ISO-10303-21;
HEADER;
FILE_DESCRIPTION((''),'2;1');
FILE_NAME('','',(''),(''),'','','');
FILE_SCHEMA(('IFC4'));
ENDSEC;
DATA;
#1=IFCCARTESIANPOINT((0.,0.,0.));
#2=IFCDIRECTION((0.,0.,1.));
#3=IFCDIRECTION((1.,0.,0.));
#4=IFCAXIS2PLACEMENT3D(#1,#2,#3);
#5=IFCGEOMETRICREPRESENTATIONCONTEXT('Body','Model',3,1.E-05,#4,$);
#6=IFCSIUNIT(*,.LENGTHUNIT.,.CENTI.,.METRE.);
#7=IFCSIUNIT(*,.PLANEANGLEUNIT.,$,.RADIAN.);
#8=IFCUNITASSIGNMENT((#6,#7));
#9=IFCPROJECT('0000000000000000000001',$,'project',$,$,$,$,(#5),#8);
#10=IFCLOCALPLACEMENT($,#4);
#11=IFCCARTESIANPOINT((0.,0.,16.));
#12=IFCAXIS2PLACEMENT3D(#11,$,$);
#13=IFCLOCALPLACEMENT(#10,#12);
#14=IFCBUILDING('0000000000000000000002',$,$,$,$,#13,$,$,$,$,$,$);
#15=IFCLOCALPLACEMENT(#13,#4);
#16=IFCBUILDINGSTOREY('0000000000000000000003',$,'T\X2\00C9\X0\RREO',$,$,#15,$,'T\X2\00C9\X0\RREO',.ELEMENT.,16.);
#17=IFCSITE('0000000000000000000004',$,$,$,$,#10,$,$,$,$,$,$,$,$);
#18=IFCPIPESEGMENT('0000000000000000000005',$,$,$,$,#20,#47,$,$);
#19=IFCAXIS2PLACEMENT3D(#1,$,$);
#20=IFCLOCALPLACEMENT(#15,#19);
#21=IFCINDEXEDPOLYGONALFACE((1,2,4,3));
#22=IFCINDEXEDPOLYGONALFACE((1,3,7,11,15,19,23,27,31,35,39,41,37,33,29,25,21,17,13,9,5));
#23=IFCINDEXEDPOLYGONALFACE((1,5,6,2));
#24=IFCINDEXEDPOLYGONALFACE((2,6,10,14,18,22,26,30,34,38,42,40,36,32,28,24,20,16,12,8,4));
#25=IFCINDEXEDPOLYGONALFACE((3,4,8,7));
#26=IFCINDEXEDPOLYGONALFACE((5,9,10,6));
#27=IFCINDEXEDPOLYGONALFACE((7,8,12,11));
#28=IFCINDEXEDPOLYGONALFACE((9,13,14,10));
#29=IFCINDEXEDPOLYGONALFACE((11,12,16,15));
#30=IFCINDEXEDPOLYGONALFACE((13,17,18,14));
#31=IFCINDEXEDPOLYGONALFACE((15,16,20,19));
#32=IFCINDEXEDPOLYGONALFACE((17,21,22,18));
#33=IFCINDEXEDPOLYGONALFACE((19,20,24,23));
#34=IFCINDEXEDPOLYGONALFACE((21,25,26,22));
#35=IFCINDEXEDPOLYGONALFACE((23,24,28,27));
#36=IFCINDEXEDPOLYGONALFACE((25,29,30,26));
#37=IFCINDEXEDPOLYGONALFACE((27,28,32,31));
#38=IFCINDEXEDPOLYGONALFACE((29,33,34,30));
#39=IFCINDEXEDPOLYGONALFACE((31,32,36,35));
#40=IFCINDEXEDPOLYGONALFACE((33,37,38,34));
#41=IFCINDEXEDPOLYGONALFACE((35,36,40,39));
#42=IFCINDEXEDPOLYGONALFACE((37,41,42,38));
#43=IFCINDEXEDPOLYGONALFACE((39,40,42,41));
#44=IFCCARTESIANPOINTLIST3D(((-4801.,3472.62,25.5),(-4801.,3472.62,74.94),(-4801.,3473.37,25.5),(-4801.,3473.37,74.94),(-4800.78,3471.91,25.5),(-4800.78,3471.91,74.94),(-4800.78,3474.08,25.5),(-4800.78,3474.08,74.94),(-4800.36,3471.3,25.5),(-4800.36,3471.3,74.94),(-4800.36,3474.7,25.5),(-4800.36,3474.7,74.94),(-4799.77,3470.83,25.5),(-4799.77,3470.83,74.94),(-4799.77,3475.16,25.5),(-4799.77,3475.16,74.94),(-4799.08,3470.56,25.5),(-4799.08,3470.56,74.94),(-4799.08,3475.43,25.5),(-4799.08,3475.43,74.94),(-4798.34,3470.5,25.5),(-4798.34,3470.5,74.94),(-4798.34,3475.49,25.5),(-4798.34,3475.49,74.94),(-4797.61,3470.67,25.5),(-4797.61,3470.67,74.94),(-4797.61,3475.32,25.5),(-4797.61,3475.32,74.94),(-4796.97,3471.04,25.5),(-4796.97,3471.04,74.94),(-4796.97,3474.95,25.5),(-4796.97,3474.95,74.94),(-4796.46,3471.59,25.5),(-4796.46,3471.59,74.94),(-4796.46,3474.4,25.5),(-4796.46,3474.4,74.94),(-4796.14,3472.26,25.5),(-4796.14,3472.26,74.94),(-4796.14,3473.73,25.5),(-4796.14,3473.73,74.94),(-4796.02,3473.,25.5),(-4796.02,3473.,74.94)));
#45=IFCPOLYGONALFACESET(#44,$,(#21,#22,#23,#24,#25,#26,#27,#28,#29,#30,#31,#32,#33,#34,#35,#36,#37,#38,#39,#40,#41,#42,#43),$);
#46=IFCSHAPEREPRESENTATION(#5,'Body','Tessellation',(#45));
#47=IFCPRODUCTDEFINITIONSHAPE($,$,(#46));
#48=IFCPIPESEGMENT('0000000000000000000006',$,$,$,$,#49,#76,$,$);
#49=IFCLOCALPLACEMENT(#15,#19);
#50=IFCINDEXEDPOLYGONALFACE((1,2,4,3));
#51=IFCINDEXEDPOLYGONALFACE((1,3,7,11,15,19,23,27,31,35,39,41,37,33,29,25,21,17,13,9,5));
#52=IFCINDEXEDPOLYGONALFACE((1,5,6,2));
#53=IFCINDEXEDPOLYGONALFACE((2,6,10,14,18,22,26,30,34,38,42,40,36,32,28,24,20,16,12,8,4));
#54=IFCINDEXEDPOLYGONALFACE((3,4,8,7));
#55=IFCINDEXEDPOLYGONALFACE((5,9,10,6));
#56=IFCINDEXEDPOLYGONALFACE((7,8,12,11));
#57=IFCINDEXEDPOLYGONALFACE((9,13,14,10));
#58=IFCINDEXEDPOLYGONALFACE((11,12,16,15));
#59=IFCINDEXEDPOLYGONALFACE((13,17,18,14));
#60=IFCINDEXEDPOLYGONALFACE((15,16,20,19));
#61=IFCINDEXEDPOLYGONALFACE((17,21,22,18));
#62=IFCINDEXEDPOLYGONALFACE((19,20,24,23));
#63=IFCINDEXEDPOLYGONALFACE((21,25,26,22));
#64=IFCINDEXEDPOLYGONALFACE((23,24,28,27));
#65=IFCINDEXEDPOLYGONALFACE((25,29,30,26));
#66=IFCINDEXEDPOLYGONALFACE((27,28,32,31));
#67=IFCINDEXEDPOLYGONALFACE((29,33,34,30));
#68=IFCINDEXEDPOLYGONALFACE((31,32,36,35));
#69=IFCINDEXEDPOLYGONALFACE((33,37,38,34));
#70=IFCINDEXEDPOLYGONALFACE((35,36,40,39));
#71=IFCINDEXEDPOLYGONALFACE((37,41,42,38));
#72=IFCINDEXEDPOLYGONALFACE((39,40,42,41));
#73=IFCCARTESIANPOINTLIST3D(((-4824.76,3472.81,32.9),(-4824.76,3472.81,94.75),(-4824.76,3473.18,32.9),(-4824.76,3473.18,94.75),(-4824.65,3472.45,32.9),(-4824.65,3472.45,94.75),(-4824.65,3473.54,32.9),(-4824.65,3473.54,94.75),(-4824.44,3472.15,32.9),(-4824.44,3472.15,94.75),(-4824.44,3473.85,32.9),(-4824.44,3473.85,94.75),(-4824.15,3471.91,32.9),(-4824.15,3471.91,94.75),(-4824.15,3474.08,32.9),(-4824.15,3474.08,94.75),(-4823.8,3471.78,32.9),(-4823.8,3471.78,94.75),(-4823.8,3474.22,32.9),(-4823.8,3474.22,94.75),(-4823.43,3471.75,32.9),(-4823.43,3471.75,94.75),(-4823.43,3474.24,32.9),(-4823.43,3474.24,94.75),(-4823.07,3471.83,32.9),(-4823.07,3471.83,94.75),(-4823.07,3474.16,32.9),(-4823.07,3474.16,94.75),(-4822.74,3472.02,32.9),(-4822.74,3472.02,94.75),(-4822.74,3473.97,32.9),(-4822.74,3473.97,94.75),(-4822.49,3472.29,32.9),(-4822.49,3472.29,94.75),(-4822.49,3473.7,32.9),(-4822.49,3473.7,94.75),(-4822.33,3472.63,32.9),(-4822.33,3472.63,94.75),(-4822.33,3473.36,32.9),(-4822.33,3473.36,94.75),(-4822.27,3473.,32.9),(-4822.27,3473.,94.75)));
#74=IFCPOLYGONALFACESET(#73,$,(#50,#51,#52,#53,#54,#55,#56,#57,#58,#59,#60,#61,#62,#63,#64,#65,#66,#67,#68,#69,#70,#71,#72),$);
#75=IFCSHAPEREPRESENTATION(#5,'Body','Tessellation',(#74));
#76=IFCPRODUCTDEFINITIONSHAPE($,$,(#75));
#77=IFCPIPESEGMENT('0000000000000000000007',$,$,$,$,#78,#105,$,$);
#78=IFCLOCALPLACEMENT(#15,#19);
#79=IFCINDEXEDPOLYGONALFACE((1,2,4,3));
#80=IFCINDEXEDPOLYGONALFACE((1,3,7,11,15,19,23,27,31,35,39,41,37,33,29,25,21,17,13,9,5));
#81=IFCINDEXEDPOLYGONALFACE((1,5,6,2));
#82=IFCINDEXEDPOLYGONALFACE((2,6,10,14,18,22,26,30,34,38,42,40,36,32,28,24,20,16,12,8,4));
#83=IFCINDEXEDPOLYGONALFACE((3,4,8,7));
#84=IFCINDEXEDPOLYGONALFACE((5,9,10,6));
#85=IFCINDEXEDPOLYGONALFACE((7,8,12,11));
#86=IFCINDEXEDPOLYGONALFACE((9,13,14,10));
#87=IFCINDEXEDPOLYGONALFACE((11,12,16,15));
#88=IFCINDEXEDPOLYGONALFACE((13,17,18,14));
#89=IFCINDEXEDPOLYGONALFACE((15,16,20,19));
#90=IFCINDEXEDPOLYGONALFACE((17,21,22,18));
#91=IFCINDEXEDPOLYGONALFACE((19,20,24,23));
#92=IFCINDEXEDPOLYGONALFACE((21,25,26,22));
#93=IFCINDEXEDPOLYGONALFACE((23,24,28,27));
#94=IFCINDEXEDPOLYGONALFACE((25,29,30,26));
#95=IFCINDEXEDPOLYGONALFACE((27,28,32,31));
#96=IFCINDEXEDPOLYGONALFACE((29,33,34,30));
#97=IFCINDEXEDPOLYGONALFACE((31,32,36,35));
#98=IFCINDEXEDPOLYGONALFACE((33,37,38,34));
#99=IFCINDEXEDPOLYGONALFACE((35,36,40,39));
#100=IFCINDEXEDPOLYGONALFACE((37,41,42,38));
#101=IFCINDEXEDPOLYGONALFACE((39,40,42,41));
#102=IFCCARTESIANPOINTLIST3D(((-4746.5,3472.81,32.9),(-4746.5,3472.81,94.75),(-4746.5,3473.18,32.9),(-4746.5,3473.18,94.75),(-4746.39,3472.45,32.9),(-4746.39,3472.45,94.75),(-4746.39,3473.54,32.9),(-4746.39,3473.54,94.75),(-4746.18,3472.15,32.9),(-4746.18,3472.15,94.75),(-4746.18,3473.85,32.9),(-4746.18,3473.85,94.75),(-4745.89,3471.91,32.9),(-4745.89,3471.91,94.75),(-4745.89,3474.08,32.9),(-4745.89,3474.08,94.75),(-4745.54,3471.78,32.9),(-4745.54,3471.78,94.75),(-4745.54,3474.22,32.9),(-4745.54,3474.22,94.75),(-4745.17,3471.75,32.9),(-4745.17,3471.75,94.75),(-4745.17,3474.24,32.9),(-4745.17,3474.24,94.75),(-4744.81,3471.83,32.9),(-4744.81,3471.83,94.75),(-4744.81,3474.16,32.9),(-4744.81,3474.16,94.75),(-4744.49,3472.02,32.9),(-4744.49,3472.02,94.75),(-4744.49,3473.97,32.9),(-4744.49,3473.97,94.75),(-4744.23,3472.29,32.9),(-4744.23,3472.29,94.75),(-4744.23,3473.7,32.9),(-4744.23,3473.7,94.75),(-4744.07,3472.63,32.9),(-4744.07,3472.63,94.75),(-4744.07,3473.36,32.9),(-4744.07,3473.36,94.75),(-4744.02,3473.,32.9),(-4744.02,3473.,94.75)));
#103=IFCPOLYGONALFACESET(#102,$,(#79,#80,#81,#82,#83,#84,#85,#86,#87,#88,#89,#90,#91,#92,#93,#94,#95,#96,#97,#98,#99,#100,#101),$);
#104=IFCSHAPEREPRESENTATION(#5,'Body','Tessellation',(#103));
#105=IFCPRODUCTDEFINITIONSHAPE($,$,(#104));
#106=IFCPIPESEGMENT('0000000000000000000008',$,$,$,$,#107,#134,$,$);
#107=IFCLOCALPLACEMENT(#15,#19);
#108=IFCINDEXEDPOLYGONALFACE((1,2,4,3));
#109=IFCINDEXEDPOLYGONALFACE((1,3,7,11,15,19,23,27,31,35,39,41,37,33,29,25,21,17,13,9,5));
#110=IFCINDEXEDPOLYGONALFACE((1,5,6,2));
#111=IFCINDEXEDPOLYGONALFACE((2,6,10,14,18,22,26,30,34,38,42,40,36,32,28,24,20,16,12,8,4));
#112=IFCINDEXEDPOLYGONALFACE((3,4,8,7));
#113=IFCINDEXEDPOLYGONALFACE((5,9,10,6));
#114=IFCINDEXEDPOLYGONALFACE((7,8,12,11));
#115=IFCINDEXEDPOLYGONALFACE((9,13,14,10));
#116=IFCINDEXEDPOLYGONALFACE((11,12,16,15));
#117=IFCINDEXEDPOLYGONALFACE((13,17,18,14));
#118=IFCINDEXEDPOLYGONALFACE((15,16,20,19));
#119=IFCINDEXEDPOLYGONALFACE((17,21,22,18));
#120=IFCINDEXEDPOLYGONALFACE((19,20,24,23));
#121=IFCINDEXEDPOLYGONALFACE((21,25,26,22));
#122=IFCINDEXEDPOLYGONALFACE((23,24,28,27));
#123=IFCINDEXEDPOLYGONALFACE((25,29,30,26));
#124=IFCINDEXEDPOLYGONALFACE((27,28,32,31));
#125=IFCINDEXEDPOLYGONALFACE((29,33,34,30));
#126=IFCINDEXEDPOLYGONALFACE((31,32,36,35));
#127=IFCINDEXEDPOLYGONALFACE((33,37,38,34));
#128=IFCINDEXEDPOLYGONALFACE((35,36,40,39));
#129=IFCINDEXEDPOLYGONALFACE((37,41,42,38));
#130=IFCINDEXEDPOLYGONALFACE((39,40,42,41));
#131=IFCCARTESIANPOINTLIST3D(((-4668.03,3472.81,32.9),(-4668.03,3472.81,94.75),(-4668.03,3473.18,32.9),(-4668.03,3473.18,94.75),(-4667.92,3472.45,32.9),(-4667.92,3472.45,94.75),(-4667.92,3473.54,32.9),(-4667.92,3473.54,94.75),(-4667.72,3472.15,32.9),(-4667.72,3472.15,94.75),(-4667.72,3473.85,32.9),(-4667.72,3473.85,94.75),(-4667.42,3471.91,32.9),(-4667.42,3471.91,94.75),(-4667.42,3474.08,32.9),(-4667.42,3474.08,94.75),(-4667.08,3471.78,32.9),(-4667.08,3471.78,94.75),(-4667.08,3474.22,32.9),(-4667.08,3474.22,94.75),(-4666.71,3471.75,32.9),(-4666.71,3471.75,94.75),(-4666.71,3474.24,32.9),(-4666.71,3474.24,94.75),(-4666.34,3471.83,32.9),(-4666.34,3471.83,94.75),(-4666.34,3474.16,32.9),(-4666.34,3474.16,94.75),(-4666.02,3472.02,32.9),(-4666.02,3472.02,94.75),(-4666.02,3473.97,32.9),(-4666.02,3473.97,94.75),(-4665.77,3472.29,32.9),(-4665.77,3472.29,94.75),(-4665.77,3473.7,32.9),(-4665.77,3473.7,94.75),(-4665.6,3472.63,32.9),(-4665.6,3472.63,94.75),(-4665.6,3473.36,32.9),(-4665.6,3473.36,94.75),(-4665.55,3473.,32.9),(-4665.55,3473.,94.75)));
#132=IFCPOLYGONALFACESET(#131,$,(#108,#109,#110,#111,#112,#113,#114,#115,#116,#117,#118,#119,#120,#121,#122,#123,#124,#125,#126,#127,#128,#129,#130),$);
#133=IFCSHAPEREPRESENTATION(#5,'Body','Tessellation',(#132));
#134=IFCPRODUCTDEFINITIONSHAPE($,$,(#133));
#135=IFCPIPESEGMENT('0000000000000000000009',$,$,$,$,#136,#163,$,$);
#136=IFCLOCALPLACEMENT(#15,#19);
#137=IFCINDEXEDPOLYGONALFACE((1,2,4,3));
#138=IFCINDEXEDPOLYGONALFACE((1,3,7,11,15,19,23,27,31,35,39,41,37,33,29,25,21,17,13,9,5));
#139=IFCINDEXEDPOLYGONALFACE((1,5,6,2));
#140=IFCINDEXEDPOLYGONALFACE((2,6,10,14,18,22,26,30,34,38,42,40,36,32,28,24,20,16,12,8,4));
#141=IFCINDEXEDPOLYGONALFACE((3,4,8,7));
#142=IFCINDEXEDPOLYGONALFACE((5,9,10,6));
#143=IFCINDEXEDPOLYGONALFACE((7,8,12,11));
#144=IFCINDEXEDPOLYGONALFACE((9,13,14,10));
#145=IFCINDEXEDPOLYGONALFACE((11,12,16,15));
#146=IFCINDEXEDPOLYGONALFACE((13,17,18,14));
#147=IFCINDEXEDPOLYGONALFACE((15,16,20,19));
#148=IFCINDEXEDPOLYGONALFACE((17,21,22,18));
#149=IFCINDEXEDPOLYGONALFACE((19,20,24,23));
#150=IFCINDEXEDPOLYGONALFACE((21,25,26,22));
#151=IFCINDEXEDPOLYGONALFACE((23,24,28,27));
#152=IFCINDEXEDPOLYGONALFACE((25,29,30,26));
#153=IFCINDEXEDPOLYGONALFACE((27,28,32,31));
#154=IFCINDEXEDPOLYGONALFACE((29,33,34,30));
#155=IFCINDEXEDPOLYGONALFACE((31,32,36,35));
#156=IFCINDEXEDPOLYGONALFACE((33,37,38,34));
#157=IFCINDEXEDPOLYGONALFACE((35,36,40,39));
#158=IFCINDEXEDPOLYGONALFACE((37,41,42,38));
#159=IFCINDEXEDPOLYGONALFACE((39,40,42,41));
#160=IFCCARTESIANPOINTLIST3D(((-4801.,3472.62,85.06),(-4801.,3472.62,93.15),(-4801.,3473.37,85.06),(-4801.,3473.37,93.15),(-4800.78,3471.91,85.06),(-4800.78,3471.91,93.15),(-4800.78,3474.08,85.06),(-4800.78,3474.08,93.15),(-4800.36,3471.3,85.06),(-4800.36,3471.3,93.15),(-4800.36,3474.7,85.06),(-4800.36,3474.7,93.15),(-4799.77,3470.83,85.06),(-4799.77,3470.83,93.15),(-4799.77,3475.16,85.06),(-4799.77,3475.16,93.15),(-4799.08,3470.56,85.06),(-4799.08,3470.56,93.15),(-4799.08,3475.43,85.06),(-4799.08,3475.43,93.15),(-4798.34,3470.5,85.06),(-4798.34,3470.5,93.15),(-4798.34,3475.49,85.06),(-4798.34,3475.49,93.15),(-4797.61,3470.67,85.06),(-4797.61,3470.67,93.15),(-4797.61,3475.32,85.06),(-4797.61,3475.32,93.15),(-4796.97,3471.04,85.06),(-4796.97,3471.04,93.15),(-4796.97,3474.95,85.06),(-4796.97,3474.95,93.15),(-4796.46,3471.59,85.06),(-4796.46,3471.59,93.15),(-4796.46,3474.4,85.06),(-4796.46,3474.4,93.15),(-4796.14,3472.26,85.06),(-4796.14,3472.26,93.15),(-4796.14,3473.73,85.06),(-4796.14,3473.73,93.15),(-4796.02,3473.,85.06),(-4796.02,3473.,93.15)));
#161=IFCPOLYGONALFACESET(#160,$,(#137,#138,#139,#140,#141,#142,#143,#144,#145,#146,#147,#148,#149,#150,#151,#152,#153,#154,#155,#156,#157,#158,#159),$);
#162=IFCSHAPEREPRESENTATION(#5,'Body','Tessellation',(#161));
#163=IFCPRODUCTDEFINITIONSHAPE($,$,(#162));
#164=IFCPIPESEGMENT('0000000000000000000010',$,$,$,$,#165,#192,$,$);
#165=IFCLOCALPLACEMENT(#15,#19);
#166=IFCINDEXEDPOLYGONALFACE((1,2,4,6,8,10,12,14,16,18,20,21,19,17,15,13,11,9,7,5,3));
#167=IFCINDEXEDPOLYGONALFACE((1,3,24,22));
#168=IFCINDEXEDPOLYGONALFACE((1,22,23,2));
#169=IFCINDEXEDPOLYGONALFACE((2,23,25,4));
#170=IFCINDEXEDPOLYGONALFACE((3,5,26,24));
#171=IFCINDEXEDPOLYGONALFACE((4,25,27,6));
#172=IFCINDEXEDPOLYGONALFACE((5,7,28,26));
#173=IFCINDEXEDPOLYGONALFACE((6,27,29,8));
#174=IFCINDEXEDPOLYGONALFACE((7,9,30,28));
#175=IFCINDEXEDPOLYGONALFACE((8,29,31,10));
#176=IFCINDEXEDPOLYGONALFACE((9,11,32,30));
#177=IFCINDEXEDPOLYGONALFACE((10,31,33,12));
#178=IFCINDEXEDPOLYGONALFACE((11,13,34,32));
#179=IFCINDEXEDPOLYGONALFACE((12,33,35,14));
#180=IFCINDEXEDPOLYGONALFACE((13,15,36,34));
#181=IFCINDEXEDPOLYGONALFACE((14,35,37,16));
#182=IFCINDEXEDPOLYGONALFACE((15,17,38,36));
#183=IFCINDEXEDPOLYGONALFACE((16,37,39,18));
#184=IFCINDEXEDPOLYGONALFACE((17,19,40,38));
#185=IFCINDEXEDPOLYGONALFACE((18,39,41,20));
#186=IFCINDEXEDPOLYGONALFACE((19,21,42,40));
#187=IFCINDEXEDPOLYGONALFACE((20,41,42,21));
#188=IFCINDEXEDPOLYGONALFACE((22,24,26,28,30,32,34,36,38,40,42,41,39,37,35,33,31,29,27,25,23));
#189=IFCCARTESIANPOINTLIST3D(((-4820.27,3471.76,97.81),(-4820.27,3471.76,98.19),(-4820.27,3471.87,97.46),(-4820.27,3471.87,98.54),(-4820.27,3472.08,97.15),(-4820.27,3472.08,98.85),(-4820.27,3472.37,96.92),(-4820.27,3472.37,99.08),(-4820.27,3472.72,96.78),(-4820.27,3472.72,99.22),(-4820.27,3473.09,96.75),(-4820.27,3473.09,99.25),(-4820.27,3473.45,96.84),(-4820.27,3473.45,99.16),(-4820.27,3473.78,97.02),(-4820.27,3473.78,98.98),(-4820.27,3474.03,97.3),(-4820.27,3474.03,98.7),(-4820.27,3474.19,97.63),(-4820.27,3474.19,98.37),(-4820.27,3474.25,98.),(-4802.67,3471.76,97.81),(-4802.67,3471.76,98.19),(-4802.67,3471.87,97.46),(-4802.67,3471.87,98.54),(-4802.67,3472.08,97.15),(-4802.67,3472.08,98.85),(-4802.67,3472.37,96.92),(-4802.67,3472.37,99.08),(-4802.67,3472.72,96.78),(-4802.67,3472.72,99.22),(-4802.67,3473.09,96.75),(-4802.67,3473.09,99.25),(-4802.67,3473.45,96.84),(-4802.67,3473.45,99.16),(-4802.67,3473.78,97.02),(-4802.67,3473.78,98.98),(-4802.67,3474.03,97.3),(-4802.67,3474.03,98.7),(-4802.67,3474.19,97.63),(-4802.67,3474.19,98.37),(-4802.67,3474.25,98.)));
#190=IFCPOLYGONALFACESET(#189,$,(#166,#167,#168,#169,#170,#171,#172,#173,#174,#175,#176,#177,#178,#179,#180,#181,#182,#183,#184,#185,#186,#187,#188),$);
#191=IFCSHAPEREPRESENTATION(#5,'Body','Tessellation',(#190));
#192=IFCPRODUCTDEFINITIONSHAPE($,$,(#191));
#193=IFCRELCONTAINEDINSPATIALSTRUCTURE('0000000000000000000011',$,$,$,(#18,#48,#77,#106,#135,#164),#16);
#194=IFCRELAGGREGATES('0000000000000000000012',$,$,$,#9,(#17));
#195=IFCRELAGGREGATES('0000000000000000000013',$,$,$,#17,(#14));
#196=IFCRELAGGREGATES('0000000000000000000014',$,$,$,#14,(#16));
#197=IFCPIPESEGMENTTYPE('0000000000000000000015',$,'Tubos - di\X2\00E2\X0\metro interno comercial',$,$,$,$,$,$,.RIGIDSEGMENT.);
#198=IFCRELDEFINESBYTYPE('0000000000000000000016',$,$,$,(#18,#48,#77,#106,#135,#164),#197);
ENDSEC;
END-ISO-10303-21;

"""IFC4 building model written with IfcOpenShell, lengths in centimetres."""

from ifc_helpers import new_model, si_unit, frame, origin_with_axes, origin_2d_with_axis, place, context, project, spatial, circle, extrude, type_object, element, save


model = new_model("IFC4")

# Units and contexts
model_context = context("Model", 3, precision=1e-05, world=origin_with_axes(), identifier="Body")
ifc_project = project(units=[si_unit("LENGTHUNIT", "METRE", prefix="CENTI"), si_unit("PLANEANGLEUNIT", "RADIAN")], contexts=[model_context])

# Site, building, storey
site_placement = place(None, origin_with_axes())
site = spatial("IfcSite", under=ifc_project, at=site_placement)
building_placement = place(site_placement, frame((0.0, 0.0, 16.0)))
building = spatial("IfcBuilding", under=site, at=building_placement)
storey_placement = place(building_placement, origin_with_axes())
storey = spatial("IfcBuildingStorey", under=building, at=storey_placement, Name="TÉRREO", LongName="TÉRREO", CompositionType="ELEMENT", Elevation=16.0)

# Pipe segments
pipe_segment_type = type_object("IfcPipeSegmentType", Name="Tubos - diâmetro interno comercial", PredefinedType="RIGIDSEGMENT")
for number, where, z_axis, x_axis in (
    (1, (-4798.52, 3473.0, 74.94), (0.0, 0.0, 1.0), (1.0, 0.0, 0.0)),
):
    element("IfcPipeSegment", number, at=place(storey_placement, frame(where, z_axis=z_axis, x_axis=x_axis)), inside=storey, type_object=pipe_segment_type, context=model_context, shape_type="SolidModel", body=[
        extrude(circle(Radius=2.5, at=origin_2d_with_axis()), frame((0.0, 0.0, 0.0), z_axis=(0.0, 0.0, -1.0), x_axis=(1.0, 0.0, 0.0)), (0.0, 0.0, 1.0), 49.44),
    ])
for number, where, z_axis, x_axis in (
    (2, (-4823.52, 3473.0, 94.75), (0.0, 0.0, 1.0), (1.0, 0.0, 0.0)),
    (3, (-4745.27, 3473.0, 94.75), (0.0, 0.0, 1.0), (1.0, 0.0, 0.0)),
    (4, (-4666.8, 3473.0, 94.75), (0.0, 0.0, 1.0), (1.0, 0.0, 0.0)),
):
    element("IfcPipeSegment", number, at=place(storey_placement, frame(where, z_axis=z_axis, x_axis=x_axis)), inside=storey, type_object=pipe_segment_type, context=model_context, shape_type="SolidModel", body=[
        extrude(circle(Radius=1.25, at=origin_2d_with_axis()), frame((0.0, 0.0, 0.0), z_axis=(0.0, 0.0, -1.0), x_axis=(1.0, 0.0, 0.0)), (0.0, 0.0, 1.0), 61.85),
    ])
pipe_segment_1_placement = place(storey_placement, frame((-4798.52, 3473.0, 93.15), z_axis=(0.0, 0.0, 1.0), x_axis=(1.0, 0.0, 0.0)))
element("IfcPipeSegment", 5, at=pipe_segment_1_placement, inside=storey, type_object=pipe_segment_type, context=model_context, shape_type="SolidModel", body=[
    extrude(circle(Radius=2.5, at=origin_2d_with_axis()), frame((0.0, 0.0, 0.0), z_axis=(0.0, 0.0, -1.0), x_axis=(1.0, 0.0, 0.0)), (0.0, 0.0, 1.0), 8.09),
])
pipe_segment_2_placement = place(storey_placement, frame((-4811.47, 3473.0, 99.25), z_axis=(0.0, 0.0, 1.0), x_axis=(1.0, 0.0, 0.0)))
element("IfcPipeSegment", 6, at=pipe_segment_2_placement, inside=storey, type_object=pipe_segment_type, context=model_context, shape_type="SolidModel", body=[
    extrude(circle(Radius=1.25, at=origin_2d_with_axis()), frame((8.8, 0.0, -1.25), z_axis=(-1.0, 0.0, 0.0), x_axis=(0.0, 1.0, 0.0)), (0.0, 0.0, 1.0), 17.6),
])

save(model, "model.ifc")
